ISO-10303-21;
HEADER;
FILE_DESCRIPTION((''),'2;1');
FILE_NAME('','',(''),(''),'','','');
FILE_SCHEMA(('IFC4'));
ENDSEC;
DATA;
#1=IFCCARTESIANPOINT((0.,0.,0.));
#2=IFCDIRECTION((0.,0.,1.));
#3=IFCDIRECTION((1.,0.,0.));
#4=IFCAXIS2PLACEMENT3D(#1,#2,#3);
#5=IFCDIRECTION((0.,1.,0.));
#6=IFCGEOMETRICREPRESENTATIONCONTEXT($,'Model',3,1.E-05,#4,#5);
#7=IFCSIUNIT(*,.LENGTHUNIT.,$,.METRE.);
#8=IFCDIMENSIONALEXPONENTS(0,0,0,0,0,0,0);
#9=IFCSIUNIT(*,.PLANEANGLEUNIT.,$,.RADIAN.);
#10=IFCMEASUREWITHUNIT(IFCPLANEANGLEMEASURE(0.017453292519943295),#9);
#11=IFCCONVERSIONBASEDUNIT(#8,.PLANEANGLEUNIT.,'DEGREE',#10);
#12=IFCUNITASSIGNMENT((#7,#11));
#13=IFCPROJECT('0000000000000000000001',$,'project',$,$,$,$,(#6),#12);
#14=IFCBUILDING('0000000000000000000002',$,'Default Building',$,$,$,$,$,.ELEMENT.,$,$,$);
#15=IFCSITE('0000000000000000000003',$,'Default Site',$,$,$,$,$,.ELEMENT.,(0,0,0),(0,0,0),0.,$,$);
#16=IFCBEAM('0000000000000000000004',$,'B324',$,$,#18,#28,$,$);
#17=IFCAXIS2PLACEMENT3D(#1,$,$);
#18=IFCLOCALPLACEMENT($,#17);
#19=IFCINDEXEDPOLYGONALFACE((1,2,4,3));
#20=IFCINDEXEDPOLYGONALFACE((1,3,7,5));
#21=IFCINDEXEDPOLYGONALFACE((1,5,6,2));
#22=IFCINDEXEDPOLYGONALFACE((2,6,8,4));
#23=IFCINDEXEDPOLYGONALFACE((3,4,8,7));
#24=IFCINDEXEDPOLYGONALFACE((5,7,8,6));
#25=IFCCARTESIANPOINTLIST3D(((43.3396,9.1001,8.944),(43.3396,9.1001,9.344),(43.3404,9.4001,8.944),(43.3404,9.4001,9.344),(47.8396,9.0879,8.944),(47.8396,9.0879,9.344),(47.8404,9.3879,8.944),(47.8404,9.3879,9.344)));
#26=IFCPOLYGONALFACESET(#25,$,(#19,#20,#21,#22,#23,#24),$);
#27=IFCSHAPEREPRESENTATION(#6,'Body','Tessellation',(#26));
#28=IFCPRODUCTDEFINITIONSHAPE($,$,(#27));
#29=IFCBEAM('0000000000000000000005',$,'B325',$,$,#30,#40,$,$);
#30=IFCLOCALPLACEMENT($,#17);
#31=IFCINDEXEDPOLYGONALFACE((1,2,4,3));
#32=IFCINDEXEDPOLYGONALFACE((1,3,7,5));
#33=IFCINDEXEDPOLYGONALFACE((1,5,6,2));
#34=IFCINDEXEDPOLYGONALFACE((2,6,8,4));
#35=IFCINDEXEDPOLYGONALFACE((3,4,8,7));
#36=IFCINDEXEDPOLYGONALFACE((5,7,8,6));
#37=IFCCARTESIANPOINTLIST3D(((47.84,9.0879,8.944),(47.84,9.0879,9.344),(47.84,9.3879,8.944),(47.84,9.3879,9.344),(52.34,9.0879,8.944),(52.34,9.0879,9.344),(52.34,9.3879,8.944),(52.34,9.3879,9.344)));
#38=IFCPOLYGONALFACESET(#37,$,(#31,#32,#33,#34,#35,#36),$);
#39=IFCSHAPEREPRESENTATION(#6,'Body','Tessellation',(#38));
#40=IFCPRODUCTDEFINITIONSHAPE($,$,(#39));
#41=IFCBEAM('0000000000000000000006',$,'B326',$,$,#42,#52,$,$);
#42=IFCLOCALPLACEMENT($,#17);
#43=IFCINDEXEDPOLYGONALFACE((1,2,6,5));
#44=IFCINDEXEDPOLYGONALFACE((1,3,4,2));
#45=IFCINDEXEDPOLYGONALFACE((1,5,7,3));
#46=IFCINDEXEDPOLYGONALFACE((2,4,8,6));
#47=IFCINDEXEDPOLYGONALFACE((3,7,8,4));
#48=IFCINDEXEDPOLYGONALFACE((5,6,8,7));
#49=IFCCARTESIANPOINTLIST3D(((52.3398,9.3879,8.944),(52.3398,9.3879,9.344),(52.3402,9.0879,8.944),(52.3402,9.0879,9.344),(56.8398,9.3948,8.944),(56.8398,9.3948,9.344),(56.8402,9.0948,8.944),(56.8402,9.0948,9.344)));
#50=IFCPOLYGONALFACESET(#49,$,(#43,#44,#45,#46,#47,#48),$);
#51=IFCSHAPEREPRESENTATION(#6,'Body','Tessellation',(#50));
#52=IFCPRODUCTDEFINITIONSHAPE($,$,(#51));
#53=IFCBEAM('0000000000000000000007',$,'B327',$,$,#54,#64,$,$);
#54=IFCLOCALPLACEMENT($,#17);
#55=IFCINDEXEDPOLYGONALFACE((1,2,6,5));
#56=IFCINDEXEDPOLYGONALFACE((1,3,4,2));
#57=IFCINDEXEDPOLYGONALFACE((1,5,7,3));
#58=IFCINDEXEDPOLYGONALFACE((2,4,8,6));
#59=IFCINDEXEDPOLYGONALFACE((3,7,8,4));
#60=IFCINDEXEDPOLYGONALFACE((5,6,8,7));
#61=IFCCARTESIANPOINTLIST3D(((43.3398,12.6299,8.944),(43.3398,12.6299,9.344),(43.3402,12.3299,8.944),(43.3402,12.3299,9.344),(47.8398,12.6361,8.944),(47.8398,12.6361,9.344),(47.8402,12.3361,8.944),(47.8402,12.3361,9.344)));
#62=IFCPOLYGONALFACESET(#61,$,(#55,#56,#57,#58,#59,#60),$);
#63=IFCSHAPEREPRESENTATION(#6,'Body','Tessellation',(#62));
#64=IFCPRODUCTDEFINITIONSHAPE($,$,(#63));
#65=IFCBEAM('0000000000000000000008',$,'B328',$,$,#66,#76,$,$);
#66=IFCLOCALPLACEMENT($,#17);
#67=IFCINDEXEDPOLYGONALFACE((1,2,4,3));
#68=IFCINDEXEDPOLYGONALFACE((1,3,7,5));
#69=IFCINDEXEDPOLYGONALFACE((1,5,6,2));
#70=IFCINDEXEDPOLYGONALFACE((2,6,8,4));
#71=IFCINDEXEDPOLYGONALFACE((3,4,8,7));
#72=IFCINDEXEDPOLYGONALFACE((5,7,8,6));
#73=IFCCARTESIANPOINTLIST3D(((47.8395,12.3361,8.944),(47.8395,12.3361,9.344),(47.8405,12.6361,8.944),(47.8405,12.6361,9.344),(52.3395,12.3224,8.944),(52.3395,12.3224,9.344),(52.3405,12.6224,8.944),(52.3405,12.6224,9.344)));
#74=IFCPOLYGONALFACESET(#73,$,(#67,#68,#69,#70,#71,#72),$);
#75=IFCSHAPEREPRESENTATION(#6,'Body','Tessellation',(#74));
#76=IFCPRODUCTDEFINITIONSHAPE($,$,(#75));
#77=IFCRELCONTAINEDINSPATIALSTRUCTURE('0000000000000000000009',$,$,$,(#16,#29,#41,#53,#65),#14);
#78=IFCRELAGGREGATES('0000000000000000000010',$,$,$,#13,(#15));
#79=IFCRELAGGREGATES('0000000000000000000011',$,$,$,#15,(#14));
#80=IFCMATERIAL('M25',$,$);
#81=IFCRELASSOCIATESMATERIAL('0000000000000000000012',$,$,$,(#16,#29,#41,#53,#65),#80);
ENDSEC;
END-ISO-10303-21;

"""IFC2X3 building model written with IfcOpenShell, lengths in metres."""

from ifc_helpers import new_model, entity, si_unit, converted_unit, direction, frame, frame_2d, origin_with_axes, place, context, project, spatial, rectangle, extrude, material, element, save


model = new_model("IFC2X3")

# Units and contexts
model_context = context("Model", 3, precision=1e-05, world=origin_with_axes(), true_north=direction((0.0, 1.0, 0.0)))
ifc_project = project(units=[si_unit("LENGTHUNIT", "METRE"), converted_unit("PLANEANGLEUNIT", "DEGREE", entity("IfcPlaneAngleMeasure", 0.017453292519943295), si_unit("PLANEANGLEUNIT", "RADIAN"), dimensions=[0, 0, 0, 0, 0, 0, 0])], contexts=[model_context])

# Site, building
site = spatial("IfcSite", under=ifc_project, Name="Default Site", CompositionType="ELEMENT", RefLatitude=(0, 0, 0), RefLongitude=(0, 0, 0), RefElevation=0.0)
building = spatial("IfcBuilding", under=site, Name="Default Building", CompositionType="ELEMENT")

# Beams
ifc_material = material(Name="M25")
placement = place(None, origin_with_axes())
element("IfcBeam", 1, at=placement, inside=building, material=ifc_material, Name="B324", context=model_context, shape_type="SweptSolid", body=[
    extrude(rectangle(XDim=0.3, YDim=0.4, at=frame_2d((0.0, 0.0), x_axis=(0.0, 1.0, 0.0))), frame((43.34, 9.2501, 9.144), z_axis=(0.999996, -0.002702, 0.0), x_axis=(0.0, 0.0, -1.0)), (0.0, 0.0, 1.0), 4.5),
])
element("IfcBeam", 2, at=placement, inside=building, material=ifc_material, Name="B325", context=model_context, shape_type="SweptSolid", body=[
    extrude(rectangle(XDim=0.3, YDim=0.4, at=frame_2d((0.0, 0.0), x_axis=(0.0, 1.0, 0.0))), frame((47.84, 9.2379, 9.144), z_axis=(1.0, 0.0, 0.0), x_axis=(0.0, 0.0, -1.0)), (0.0, 0.0, 1.0), 4.5),
])
element("IfcBeam", 3, at=placement, inside=building, material=ifc_material, Name="B326", context=model_context, shape_type="SweptSolid", body=[
    extrude(rectangle(XDim=0.3, YDim=0.4, at=frame_2d((0.0, 0.0), x_axis=(0.0, 1.0, 0.0))), frame((52.34, 9.2379, 9.144), z_axis=(0.999999, 0.001537, 0.0), x_axis=(0.0, 0.0, -1.0)), (0.0, 0.0, 1.0), 4.5),
])
element("IfcBeam", 4, at=placement, inside=building, material=ifc_material, Name="B327", context=model_context, shape_type="SweptSolid", body=[
    extrude(rectangle(XDim=0.3, YDim=0.4, at=frame_2d((0.0, 0.0), x_axis=(0.0, 1.0, 0.0))), frame((43.34, 12.4799, 9.144), z_axis=(0.999999, 0.001374, 0.0), x_axis=(0.0, 0.0, -1.0)), (0.0, 0.0, 1.0), 4.5),
])
element("IfcBeam", 5, at=placement, inside=building, material=ifc_material, Name="B328", context=model_context, shape_type="SweptSolid", body=[
    extrude(rectangle(XDim=0.3, YDim=0.4, at=frame_2d((0.0, 0.0), x_axis=(0.0, 1.0, 0.0))), frame((47.84, 12.4861, 9.144), z_axis=(0.999995, -0.003045, 0.0), x_axis=(0.0, 0.0, -1.0)), (0.0, 0.0, 1.0), 4.5),
])

save(model, "model.ifc")
